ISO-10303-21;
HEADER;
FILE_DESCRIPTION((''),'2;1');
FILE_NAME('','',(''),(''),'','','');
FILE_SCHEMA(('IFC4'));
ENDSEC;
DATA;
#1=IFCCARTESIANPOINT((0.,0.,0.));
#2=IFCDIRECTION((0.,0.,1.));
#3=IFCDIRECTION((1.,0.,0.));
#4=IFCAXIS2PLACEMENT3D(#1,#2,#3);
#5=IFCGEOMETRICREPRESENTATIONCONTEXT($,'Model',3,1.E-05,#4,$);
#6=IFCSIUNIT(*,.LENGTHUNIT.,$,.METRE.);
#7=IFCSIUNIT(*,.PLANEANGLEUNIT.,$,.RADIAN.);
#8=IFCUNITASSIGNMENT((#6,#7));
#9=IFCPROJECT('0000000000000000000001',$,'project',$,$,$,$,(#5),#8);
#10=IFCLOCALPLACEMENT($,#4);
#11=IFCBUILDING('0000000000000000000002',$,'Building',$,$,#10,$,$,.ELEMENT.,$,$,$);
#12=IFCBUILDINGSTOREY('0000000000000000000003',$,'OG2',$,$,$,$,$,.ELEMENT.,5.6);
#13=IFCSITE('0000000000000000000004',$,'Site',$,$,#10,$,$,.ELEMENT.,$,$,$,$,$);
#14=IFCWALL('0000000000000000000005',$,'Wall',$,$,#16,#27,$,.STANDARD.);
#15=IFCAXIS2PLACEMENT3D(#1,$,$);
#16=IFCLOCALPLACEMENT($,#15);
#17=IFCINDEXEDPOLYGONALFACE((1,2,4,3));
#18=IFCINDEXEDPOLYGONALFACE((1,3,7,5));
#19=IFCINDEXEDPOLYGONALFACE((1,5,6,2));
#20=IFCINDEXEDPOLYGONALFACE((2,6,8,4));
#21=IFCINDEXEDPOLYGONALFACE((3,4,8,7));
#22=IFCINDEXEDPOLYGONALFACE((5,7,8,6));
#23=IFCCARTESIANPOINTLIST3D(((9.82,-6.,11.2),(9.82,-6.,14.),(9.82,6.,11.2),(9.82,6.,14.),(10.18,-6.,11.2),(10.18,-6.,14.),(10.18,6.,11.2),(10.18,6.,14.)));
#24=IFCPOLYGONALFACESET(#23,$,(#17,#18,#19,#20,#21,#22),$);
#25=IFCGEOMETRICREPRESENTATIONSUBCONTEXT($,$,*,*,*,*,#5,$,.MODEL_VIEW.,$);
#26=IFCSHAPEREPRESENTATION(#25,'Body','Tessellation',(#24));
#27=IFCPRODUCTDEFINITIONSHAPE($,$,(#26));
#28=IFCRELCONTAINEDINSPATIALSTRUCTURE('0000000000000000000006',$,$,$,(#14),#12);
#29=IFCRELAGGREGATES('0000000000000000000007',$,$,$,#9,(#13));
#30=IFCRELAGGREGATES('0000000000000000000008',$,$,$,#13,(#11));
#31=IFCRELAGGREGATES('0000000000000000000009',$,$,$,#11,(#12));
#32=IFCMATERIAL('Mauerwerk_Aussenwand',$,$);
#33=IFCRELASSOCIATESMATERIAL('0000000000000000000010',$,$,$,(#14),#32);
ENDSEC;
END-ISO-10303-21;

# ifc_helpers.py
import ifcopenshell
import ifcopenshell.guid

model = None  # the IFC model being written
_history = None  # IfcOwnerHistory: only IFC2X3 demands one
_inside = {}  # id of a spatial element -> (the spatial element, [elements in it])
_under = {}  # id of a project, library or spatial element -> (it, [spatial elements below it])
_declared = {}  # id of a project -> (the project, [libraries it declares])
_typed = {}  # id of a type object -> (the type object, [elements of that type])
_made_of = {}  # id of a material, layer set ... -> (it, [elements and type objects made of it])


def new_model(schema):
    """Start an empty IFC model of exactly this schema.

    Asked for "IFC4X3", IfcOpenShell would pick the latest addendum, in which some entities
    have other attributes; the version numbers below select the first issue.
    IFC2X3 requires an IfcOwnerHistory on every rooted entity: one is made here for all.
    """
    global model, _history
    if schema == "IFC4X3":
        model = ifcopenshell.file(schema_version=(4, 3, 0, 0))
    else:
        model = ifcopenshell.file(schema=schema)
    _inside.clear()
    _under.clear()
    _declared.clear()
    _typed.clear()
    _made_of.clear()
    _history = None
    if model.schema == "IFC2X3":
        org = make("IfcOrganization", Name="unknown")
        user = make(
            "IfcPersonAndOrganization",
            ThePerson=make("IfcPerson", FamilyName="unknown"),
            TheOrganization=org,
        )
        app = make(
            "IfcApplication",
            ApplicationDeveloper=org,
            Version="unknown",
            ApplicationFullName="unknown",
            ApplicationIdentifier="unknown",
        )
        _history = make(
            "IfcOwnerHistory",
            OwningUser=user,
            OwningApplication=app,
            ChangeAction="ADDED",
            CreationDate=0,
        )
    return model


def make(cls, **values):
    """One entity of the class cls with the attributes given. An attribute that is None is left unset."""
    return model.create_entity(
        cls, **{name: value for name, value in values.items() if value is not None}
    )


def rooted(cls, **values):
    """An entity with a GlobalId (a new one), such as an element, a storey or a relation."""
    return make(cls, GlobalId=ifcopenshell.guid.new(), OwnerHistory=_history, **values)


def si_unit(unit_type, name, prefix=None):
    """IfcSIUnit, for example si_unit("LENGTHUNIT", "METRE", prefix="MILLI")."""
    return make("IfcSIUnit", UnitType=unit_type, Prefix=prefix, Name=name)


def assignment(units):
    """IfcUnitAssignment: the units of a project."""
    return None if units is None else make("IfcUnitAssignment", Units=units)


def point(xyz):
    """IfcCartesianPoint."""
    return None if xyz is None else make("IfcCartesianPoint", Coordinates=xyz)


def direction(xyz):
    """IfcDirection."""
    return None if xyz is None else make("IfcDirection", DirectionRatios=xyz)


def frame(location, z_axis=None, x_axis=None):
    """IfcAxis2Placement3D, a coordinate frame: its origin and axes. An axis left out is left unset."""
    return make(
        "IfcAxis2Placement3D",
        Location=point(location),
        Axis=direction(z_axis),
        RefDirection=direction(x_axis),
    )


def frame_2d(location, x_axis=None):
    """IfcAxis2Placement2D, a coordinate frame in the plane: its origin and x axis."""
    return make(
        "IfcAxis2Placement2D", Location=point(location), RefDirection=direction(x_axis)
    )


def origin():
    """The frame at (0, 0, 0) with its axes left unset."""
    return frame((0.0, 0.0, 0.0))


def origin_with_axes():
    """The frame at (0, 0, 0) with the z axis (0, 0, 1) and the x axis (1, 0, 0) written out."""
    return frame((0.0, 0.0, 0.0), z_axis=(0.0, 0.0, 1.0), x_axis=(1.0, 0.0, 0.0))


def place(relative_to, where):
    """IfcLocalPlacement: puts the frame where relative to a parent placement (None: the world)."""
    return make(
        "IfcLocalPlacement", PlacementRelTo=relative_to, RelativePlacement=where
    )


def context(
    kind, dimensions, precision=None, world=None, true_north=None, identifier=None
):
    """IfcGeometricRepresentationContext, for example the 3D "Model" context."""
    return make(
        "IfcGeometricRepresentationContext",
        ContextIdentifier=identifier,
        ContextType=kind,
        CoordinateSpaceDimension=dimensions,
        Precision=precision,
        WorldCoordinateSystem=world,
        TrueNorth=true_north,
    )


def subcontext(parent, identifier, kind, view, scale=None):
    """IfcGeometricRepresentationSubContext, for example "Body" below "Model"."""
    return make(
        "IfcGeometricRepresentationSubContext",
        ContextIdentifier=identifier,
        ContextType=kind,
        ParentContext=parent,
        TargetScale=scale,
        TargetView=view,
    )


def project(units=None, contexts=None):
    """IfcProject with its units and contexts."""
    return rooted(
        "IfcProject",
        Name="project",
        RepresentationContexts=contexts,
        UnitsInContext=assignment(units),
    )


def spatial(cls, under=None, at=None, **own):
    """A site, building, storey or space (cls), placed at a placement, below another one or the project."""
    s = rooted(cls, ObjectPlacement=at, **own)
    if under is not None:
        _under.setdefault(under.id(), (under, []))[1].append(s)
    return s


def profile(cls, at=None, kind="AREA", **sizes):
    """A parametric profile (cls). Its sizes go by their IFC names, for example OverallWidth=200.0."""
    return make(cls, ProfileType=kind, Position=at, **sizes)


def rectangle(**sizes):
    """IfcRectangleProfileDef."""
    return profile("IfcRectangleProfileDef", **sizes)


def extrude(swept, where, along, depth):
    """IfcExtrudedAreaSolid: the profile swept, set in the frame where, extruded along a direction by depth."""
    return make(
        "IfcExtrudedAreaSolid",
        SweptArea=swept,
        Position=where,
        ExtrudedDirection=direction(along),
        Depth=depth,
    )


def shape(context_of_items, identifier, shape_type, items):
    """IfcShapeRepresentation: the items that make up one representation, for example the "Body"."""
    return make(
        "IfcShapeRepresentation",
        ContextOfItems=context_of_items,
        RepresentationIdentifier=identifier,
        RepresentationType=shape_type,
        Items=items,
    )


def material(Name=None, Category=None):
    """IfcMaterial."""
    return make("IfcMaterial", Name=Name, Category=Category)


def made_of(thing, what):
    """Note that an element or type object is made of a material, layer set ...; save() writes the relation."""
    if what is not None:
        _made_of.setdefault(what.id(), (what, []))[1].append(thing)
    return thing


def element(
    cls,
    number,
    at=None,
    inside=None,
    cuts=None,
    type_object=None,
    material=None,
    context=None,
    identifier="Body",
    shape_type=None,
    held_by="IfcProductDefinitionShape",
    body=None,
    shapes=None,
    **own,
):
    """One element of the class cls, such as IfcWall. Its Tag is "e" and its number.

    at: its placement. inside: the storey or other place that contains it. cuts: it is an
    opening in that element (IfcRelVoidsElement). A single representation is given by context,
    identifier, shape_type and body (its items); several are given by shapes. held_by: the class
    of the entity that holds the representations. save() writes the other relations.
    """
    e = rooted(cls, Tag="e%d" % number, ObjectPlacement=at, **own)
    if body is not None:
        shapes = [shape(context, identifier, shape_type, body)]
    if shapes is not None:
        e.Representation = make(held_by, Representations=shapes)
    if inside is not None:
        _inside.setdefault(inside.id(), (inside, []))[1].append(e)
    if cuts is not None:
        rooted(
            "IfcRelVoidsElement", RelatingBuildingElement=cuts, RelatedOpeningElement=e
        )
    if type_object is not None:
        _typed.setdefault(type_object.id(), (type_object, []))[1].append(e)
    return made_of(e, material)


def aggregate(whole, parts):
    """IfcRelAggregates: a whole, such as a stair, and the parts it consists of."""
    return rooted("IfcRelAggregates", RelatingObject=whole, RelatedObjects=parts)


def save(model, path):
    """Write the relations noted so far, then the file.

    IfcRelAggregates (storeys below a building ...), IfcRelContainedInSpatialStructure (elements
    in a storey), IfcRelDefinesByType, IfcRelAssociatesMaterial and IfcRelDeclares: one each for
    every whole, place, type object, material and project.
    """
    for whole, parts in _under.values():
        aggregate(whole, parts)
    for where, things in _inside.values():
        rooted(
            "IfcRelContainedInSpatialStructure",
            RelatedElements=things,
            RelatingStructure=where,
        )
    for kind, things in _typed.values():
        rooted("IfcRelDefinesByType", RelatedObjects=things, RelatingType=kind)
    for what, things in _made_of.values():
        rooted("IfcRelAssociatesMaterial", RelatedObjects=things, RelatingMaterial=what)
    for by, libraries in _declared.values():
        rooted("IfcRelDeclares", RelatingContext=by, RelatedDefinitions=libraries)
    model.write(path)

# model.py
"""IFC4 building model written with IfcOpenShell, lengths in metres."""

from ifc_helpers import new_model, si_unit, frame, frame_2d, origin, origin_with_axes, place, context, subcontext, project, spatial, rectangle, extrude, material, element, save


model = new_model("IFC4")

# Units and contexts
model_context = context("Model", 3, precision=1e-05, world=origin_with_axes())
sub_context = subcontext(model_context, None, None, "MODEL_VIEW")
ifc_project = project(units=[si_unit("LENGTHUNIT", "METRE"), si_unit("PLANEANGLEUNIT", "RADIAN")], contexts=[model_context])

# Site, building, storey
placement_1 = place(None, origin_with_axes())
site = spatial("IfcSite", under=ifc_project, at=placement_1, Name="Site", CompositionType="ELEMENT")
building = spatial("IfcBuilding", under=site, at=placement_1, Name="Building", CompositionType="ELEMENT")
storey = spatial("IfcBuildingStorey", under=building, Name="OG2", CompositionType="ELEMENT", Elevation=5.6)

# Wall
ifc_material = material(Name="Mauerwerk_Aussenwand")
placement_2 = place(None, origin_with_axes())
placement_3 = place(placement_2, frame((0.0, 0.0, 5.6)))
wall_placement = place(placement_3, frame((10.0, -6.0, 5.6), x_axis=(0.0, 1.0, 0.0)))
element("IfcWall", 1, at=wall_placement, inside=storey, material=ifc_material, Name="Wall", PredefinedType="STANDARD", context=sub_context, shape_type="SweptSolid", body=[
    extrude(rectangle(XDim=12.0, YDim=0.36, at=frame_2d((6.0, 0.0))), origin(), (0.0, 0.0, 1.0), 2.8),
])

save(model, "model.ifc")
